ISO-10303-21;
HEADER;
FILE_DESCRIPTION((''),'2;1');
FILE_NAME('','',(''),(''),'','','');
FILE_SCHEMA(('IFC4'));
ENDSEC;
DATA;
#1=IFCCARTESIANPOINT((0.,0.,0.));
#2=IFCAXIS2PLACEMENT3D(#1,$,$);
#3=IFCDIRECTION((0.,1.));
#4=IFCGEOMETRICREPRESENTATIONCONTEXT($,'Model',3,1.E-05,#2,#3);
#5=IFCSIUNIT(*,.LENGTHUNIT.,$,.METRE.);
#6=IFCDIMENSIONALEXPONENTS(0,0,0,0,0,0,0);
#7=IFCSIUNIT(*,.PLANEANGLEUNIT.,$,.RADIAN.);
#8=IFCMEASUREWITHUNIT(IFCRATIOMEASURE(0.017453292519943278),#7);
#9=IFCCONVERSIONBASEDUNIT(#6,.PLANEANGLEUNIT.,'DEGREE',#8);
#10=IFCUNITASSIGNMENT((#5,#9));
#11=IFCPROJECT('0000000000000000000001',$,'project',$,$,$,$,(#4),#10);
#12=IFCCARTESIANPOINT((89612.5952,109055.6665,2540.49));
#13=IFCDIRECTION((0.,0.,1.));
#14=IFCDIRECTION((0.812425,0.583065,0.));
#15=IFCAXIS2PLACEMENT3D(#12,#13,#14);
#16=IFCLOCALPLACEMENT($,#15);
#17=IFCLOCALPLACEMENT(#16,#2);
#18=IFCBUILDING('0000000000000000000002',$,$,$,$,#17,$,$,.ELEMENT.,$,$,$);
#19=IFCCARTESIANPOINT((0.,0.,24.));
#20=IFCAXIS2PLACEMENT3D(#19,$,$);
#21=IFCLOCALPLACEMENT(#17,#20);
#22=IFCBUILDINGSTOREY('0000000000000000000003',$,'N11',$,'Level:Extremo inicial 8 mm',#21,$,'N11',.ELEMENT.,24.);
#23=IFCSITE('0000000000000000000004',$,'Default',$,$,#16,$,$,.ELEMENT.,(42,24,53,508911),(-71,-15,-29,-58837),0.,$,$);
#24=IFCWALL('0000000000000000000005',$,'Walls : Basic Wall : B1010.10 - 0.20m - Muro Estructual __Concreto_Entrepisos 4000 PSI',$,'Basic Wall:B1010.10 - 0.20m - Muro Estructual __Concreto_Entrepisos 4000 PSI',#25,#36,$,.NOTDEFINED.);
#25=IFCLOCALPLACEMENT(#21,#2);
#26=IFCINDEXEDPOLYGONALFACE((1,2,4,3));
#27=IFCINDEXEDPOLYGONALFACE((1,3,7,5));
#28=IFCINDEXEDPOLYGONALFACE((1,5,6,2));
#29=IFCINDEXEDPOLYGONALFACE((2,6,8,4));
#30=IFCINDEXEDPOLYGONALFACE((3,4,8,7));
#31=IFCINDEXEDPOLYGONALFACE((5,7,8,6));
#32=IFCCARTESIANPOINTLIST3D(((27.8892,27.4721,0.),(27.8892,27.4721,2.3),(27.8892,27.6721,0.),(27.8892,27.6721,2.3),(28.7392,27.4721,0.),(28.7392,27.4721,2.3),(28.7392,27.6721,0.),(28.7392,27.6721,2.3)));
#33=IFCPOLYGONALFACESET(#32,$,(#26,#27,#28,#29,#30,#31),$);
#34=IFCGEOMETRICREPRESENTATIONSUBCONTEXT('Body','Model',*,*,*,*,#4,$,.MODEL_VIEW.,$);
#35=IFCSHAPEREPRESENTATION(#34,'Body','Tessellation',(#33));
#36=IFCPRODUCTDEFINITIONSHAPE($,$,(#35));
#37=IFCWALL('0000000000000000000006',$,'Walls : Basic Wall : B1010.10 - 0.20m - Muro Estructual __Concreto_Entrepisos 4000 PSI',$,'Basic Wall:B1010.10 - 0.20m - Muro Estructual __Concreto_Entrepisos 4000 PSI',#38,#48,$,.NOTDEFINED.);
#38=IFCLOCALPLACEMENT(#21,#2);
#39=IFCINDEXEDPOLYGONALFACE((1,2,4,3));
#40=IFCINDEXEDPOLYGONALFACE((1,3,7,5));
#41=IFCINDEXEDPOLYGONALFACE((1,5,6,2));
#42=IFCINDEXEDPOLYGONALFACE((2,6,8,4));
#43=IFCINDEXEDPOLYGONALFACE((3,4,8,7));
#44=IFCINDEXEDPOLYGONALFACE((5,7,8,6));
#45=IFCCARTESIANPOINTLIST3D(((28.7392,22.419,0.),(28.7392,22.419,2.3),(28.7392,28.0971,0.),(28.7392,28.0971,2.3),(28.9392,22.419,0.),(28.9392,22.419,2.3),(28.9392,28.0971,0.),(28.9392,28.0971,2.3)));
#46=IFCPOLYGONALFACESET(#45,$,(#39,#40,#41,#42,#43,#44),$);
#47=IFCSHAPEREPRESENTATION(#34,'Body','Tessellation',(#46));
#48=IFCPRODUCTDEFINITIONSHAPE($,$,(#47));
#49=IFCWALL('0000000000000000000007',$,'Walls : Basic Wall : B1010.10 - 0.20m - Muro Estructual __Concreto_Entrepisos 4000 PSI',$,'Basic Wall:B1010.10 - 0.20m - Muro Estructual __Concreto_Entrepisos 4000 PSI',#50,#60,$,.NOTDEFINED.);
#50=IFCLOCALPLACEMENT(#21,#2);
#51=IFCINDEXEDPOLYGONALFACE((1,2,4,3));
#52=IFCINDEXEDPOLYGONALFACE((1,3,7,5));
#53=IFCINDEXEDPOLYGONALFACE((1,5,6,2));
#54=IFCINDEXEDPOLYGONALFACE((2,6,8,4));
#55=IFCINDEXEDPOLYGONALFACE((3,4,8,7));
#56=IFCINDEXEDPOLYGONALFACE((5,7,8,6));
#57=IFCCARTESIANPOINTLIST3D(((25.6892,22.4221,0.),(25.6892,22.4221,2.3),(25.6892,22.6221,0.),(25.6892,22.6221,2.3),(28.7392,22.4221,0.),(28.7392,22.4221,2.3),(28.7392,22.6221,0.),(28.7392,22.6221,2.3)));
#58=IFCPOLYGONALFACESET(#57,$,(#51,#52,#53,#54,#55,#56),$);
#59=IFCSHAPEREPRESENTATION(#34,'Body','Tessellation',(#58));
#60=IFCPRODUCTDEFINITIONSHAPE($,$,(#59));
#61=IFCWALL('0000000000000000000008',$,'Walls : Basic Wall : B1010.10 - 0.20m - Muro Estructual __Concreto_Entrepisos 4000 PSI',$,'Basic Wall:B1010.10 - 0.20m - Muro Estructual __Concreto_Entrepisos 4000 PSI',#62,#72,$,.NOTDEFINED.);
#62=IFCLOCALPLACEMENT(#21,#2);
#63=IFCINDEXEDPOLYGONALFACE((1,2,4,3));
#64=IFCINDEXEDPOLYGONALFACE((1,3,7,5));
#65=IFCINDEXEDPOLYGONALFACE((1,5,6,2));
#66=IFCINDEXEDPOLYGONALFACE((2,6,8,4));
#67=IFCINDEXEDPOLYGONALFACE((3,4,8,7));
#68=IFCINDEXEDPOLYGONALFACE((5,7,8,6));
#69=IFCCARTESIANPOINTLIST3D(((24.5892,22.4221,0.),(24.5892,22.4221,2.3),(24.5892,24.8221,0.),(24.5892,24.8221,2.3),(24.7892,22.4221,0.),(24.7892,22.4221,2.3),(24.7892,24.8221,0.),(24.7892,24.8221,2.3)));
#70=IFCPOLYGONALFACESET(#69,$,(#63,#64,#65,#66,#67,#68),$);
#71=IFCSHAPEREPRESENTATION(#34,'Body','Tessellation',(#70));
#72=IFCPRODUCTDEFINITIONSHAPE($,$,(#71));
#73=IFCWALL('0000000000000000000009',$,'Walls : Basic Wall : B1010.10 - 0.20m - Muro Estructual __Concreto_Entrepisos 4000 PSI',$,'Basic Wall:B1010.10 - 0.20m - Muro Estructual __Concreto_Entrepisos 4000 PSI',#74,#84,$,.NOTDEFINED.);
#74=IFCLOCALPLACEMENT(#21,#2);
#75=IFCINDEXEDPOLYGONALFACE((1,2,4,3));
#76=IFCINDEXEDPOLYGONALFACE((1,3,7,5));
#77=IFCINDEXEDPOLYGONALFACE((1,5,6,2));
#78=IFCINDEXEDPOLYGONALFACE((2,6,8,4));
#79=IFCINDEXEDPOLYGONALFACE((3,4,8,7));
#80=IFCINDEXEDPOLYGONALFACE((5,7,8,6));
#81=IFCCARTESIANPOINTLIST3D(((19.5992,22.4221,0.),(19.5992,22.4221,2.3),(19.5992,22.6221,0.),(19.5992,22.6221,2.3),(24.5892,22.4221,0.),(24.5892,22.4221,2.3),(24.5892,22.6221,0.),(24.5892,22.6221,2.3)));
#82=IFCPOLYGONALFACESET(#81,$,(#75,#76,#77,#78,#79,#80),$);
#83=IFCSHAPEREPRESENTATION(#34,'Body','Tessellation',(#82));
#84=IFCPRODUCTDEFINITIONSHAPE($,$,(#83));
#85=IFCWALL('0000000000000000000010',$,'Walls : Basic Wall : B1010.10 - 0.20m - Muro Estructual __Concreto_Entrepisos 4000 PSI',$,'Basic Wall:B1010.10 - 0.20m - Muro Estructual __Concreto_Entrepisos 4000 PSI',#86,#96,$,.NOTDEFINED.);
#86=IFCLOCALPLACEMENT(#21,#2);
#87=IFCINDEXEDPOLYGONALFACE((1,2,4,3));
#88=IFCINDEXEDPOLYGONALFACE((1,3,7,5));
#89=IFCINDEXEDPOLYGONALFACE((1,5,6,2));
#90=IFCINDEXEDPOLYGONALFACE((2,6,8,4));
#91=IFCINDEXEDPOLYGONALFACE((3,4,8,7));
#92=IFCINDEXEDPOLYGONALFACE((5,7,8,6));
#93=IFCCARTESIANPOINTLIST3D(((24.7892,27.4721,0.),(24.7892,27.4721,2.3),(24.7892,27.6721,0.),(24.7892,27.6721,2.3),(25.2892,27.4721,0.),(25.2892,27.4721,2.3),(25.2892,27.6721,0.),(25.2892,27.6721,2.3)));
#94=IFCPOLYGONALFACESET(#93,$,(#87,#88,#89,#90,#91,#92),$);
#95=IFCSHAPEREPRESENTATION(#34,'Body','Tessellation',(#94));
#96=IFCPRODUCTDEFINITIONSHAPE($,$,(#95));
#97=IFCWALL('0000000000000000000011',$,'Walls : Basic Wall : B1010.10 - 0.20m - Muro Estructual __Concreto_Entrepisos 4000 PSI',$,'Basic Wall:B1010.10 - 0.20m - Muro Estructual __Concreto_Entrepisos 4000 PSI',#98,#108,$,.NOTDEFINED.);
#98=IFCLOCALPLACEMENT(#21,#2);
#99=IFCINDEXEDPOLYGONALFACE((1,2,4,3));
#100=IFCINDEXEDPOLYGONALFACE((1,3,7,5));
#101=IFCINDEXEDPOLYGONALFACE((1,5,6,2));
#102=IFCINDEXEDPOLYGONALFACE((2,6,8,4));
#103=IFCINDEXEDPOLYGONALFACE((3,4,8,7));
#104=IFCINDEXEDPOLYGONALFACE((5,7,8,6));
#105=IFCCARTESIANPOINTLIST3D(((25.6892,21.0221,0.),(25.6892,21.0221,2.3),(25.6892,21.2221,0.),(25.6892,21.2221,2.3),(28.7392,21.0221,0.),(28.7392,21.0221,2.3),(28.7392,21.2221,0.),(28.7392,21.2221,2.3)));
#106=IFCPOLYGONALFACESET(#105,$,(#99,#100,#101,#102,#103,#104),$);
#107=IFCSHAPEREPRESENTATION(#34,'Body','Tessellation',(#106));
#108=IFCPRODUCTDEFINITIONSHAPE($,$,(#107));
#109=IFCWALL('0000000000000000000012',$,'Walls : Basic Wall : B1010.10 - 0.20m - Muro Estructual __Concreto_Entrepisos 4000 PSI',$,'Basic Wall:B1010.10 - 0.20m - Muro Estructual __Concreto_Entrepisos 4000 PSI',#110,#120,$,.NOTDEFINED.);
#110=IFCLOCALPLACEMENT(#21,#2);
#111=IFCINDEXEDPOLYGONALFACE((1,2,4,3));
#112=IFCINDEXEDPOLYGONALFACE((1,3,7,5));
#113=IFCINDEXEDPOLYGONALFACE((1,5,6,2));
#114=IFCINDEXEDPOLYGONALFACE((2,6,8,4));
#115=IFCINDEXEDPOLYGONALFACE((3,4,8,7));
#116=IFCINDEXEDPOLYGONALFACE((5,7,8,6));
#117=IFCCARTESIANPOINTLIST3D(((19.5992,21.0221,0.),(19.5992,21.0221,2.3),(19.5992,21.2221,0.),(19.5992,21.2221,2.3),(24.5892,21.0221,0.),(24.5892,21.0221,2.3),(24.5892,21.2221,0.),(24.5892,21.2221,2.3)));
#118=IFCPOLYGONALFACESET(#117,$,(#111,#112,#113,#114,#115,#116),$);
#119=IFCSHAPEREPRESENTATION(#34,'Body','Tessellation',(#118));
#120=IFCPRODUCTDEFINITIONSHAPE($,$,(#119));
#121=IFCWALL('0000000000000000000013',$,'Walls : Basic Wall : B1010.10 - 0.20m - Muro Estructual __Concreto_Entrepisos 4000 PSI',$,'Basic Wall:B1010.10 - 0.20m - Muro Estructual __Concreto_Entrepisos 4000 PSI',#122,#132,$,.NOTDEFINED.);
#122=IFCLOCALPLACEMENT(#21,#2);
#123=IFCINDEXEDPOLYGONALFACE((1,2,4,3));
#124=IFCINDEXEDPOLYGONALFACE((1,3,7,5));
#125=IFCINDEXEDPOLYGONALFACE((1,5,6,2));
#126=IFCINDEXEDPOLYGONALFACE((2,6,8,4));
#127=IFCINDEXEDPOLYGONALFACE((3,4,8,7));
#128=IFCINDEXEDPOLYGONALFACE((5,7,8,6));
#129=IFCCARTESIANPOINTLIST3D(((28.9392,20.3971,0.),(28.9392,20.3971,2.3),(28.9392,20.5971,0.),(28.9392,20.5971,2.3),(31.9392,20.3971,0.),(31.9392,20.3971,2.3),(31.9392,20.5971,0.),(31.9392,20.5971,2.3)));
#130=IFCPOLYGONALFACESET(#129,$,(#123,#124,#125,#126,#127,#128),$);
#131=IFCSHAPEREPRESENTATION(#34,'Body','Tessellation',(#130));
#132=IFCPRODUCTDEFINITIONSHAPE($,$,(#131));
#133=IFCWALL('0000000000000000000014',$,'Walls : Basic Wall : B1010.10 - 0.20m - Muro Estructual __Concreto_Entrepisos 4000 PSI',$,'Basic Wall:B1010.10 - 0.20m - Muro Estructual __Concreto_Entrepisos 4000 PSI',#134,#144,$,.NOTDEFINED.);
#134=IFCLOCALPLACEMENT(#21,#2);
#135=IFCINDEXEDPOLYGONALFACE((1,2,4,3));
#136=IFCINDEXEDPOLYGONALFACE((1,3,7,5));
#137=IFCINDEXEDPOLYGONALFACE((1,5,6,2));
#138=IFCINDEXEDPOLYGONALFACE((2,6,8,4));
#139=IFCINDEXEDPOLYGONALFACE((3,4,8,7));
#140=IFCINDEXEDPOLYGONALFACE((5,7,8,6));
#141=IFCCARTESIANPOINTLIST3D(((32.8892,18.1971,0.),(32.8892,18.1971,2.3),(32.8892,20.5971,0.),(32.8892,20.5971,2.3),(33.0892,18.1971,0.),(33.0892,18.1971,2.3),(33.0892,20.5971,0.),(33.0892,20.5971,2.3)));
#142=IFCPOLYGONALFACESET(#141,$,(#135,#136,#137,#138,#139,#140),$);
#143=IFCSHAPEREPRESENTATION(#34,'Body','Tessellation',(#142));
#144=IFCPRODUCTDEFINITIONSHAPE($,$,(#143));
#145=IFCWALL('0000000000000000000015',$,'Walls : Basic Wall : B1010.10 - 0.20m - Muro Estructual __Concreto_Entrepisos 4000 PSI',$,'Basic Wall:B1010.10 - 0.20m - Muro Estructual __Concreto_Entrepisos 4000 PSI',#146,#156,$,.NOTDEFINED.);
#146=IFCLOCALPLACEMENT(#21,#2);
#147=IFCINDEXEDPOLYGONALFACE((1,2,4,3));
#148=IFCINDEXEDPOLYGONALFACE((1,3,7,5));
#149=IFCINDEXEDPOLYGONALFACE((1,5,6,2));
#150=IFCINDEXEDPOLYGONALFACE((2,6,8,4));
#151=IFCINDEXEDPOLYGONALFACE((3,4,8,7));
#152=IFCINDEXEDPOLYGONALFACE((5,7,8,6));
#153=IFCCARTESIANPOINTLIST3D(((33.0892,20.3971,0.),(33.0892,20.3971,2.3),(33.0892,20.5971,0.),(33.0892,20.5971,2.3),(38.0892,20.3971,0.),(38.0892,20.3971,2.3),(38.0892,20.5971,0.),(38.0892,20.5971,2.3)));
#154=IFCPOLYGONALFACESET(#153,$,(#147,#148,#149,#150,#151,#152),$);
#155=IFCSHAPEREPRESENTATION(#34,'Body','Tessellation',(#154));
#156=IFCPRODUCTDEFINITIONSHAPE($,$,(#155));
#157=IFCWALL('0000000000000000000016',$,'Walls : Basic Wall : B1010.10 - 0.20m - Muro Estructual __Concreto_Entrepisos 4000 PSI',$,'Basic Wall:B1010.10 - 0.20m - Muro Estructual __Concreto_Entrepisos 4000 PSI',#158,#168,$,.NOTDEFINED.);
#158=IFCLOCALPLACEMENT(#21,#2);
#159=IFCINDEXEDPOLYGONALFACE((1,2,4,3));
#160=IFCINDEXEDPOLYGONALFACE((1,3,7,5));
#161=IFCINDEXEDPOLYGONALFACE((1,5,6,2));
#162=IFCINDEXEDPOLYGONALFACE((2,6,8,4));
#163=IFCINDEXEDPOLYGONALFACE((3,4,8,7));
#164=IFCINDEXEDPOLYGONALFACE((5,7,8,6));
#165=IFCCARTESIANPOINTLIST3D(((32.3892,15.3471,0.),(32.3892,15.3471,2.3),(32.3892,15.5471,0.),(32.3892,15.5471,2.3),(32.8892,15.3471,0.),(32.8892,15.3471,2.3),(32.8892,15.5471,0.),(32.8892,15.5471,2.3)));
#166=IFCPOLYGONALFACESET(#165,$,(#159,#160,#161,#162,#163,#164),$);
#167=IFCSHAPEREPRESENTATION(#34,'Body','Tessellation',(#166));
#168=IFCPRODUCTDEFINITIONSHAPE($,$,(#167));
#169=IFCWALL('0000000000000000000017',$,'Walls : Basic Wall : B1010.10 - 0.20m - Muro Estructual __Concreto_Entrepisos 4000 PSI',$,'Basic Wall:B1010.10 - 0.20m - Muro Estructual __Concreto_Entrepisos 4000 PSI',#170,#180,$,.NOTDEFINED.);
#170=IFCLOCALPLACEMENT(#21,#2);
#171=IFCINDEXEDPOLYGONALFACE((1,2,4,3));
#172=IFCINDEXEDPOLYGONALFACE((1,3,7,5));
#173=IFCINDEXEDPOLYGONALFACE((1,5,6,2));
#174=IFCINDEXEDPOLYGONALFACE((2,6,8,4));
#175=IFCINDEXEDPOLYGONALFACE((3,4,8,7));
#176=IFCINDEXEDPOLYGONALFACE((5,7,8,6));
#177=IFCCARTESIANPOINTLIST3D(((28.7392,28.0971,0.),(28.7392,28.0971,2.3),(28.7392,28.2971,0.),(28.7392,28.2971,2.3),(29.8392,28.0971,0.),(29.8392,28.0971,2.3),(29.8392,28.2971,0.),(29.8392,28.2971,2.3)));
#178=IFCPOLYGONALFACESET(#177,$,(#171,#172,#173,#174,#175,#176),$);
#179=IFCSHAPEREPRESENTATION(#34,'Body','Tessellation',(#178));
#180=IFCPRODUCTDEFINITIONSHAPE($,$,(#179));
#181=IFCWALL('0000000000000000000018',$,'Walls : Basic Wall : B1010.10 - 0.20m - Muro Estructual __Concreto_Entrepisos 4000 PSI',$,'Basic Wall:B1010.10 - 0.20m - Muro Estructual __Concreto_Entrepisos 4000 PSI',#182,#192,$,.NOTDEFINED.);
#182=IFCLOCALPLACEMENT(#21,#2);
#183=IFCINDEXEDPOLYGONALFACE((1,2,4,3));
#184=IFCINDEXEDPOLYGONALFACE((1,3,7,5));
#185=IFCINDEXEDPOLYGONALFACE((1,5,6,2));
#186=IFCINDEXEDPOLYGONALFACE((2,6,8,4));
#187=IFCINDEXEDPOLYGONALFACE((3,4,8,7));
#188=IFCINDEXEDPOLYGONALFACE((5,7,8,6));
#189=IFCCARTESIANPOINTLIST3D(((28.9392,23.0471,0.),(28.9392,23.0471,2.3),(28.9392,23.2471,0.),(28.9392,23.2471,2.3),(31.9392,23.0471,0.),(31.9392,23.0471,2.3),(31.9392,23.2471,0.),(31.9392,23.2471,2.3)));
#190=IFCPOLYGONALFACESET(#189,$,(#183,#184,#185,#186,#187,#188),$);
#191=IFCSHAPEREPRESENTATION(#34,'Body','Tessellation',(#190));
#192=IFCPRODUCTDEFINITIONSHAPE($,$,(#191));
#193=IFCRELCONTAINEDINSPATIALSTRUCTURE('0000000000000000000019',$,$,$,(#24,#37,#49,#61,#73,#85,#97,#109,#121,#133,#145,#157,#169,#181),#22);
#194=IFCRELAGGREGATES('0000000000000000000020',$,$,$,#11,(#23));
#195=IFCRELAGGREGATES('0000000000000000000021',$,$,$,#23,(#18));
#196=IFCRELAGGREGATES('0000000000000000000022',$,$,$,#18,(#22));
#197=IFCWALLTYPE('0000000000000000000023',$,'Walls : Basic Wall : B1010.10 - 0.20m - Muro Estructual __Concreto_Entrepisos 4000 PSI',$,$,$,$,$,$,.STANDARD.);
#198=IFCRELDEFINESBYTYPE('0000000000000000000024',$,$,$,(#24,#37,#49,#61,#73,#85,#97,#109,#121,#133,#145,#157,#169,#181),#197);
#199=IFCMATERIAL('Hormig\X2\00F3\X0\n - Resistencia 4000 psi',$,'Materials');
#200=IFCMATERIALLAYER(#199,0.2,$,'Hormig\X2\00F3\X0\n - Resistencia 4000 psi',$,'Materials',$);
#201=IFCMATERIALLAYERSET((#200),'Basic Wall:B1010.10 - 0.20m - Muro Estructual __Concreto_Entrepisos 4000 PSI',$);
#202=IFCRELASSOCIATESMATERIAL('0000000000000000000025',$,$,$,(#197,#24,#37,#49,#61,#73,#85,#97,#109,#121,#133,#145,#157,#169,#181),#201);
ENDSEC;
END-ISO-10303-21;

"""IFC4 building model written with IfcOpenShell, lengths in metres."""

from ifc_helpers import new_model, entity, si_unit, converted_unit, direction, frame, frame_2d, origin, place, context, subcontext, project, spatial, rectangle, extrude, material, layer, layer_set, layer_usage, type_object, element, save


model = new_model("IFC4")

# Units and contexts
model_context = context("Model", 3, precision=1e-05, world=origin(), true_north=direction((0.0, 1.0)))
body_context = subcontext(model_context, "Body", "Model", "MODEL_VIEW")
ifc_project = project(units=[si_unit("LENGTHUNIT", "METRE"), converted_unit("PLANEANGLEUNIT", "DEGREE", entity("IfcRatioMeasure", 0.017453292519943278), si_unit("PLANEANGLEUNIT", "RADIAN"), dimensions=[0, 0, 0, 0, 0, 0, 0])], contexts=[model_context])

# Site, building, storey
site_placement = place(None, frame((89612.5952, 109055.6665, 2540.49), z_axis=(0.0, 0.0, 1.0), x_axis=(0.812425, 0.583065, 0.0)))
site = spatial("IfcSite", under=ifc_project, at=site_placement, Name="Default", CompositionType="ELEMENT", RefLatitude=(42, 24, 53, 508911), RefLongitude=(-71, -15, -29, -58837), RefElevation=0.0)
building_placement = place(site_placement, origin())
building = spatial("IfcBuilding", under=site, at=building_placement, CompositionType="ELEMENT")
storey_placement = place(building_placement, frame((0.0, 0.0, 24.0)))
storey = spatial("IfcBuildingStorey", under=building, at=storey_placement, Name="N11", ObjectType="Level:Extremo inicial 8 mm", LongName="N11", CompositionType="ELEMENT", Elevation=24.0)

# Walls
ifc_material = material(Name="Hormigón - Resistencia 4000 psi", Category="Materials")
ifc_layer_1 = layer(ifc_material, 0.2, Name="Hormigón - Resistencia 4000 psi", Category="Materials")
ifc_layer_set_1 = layer_set([ifc_layer_1], Name="Basic Wall:B1010.10 - 0.20m - Muro Estructual __Concreto_Entrepisos 4000 PSI")
ifc_layer_usage_1 = layer_usage(ifc_layer_set_1, "AXIS2", "NEGATIVE", 0.1)
wall_type_1 = type_object("IfcWallType", Name="Walls : Basic Wall : B1010.10 - 0.20m - Muro Estructual __Concreto_Entrepisos 4000 PSI", PredefinedType="STANDARD", material=ifc_layer_set_1)
wall_1_placement = place(storey_placement, frame((27.8892, 27.5721, 0.0)))
element("IfcWall", 1, at=wall_1_placement, inside=storey, type_object=wall_type_1, material=ifc_layer_usage_1, Name="Walls : Basic Wall : B1010.10 - 0.20m - Muro Estructual __Concreto_Entrepisos 4000 PSI", ObjectType="Basic Wall:B1010.10 - 0.20m - Muro Estructual __Concreto_Entrepisos 4000 PSI", PredefinedType="NOTDEFINED", context=body_context, shape_type="SweptSolid", body=[
    extrude(rectangle(XDim=0.85, YDim=0.2, at=frame_2d((0.425, 0.0), x_axis=(-1.0, 0.0))), origin(), (0.0, 0.0, 1.0), 2.3),
])
ifc_layer_usage_2 = layer_usage(ifc_layer_set_1, "AXIS2", "NEGATIVE", 0.1)
wall_2_placement = place(storey_placement, frame((28.8392, 28.0971, 0.0), z_axis=(0.0, 0.0, 1.0), x_axis=(0.0, -1.0, 0.0)))
element("IfcWall", 2, at=wall_2_placement, inside=storey, type_object=wall_type_1, material=ifc_layer_usage_2, Name="Walls : Basic Wall : B1010.10 - 0.20m - Muro Estructual __Concreto_Entrepisos 4000 PSI", ObjectType="Basic Wall:B1010.10 - 0.20m - Muro Estructual __Concreto_Entrepisos 4000 PSI", PredefinedType="NOTDEFINED", context=body_context, shape_type="SweptSolid", body=[
    extrude(rectangle(XDim=5.6781, YDim=0.2, at=frame_2d((2.839, 0.0), x_axis=(-1.0, 0.0))), origin(), (0.0, 0.0, 1.0), 2.3),
])
ifc_layer_usage_3 = layer_usage(ifc_layer_set_1, "AXIS2", "NEGATIVE", 0.1)
wall_3_placement = place(storey_placement, frame((28.7392, 22.5221, 0.0), z_axis=(0.0, 0.0, 1.0), x_axis=(-1.0, 0.0, 0.0)))
element("IfcWall", 3, at=wall_3_placement, inside=storey, type_object=wall_type_1, material=ifc_layer_usage_3, Name="Walls : Basic Wall : B1010.10 - 0.20m - Muro Estructual __Concreto_Entrepisos 4000 PSI", ObjectType="Basic Wall:B1010.10 - 0.20m - Muro Estructual __Concreto_Entrepisos 4000 PSI", PredefinedType="NOTDEFINED", context=body_context, shape_type="SweptSolid", body=[
    extrude(rectangle(XDim=3.05, YDim=0.2, at=frame_2d((1.525, 0.0), x_axis=(-1.0, 0.0))), origin(), (0.0, 0.0, 1.0), 2.3),
])
ifc_layer_usage_4 = layer_usage(ifc_layer_set_1, "AXIS2", "NEGATIVE", 0.1)
wall_4_placement = place(storey_placement, frame((24.6892, 24.8221, 0.0), z_axis=(0.0, 0.0, 1.0), x_axis=(0.0, -1.0, 0.0)))
element("IfcWall", 4, at=wall_4_placement, inside=storey, type_object=wall_type_1, material=ifc_layer_usage_4, Name="Walls : Basic Wall : B1010.10 - 0.20m - Muro Estructual __Concreto_Entrepisos 4000 PSI", ObjectType="Basic Wall:B1010.10 - 0.20m - Muro Estructual __Concreto_Entrepisos 4000 PSI", PredefinedType="NOTDEFINED", context=body_context, shape_type="SweptSolid", body=[
    extrude(rectangle(XDim=2.4, YDim=0.2, at=frame_2d((1.2, 0.0), x_axis=(-1.0, 0.0))), origin(), (0.0, 0.0, 1.0), 2.3),
])
ifc_layer_usage_5 = layer_usage(ifc_layer_set_1, "AXIS2", "NEGATIVE", 0.1)
wall_5_placement = place(storey_placement, frame((24.5892, 22.5221, 0.0), z_axis=(0.0, 0.0, 1.0), x_axis=(-1.0, 0.0, 0.0)))
element("IfcWall", 5, at=wall_5_placement, inside=storey, type_object=wall_type_1, material=ifc_layer_usage_5, Name="Walls : Basic Wall : B1010.10 - 0.20m - Muro Estructual __Concreto_Entrepisos 4000 PSI", ObjectType="Basic Wall:B1010.10 - 0.20m - Muro Estructual __Concreto_Entrepisos 4000 PSI", PredefinedType="NOTDEFINED", context=body_context, shape_type="SweptSolid", body=[
    extrude(rectangle(XDim=4.99, YDim=0.2, at=frame_2d((2.495, 0.0), x_axis=(-1.0, 0.0))), origin(), (0.0, 0.0, 1.0), 2.3),
])
ifc_layer_usage_6 = layer_usage(ifc_layer_set_1, "AXIS2", "NEGATIVE", 0.1)
wall_6_placement = place(storey_placement, frame((25.2892, 27.5721, 0.0), z_axis=(0.0, 0.0, 1.0), x_axis=(-1.0, 0.0, 0.0)))
element("IfcWall", 6, at=wall_6_placement, inside=storey, type_object=wall_type_1, material=ifc_layer_usage_6, Name="Walls : Basic Wall : B1010.10 - 0.20m - Muro Estructual __Concreto_Entrepisos 4000 PSI", ObjectType="Basic Wall:B1010.10 - 0.20m - Muro Estructual __Concreto_Entrepisos 4000 PSI", PredefinedType="NOTDEFINED", context=body_context, shape_type="SweptSolid", body=[
    extrude(rectangle(XDim=0.5, YDim=0.2, at=frame_2d((0.25, 0.0), x_axis=(-1.0, 0.0))), origin(), (0.0, 0.0, 1.0), 2.3),
])
ifc_layer_usage_7 = layer_usage(ifc_layer_set_1, "AXIS2", "POSITIVE", -0.1)
wall_7_placement = place(storey_placement, frame((28.7392, 21.1221, 0.0), z_axis=(0.0, 0.0, 1.0), x_axis=(-1.0, 0.0, 0.0)))
element("IfcWall", 7, at=wall_7_placement, inside=storey, type_object=wall_type_1, material=ifc_layer_usage_7, Name="Walls : Basic Wall : B1010.10 - 0.20m - Muro Estructual __Concreto_Entrepisos 4000 PSI", ObjectType="Basic Wall:B1010.10 - 0.20m - Muro Estructual __Concreto_Entrepisos 4000 PSI", PredefinedType="NOTDEFINED", context=body_context, shape_type="SweptSolid", body=[
    extrude(rectangle(XDim=3.05, YDim=0.2, at=frame_2d((1.525, 0.0), x_axis=(-1.0, 0.0))), origin(), (0.0, 0.0, 1.0), 2.3),
])
ifc_layer_usage_8 = layer_usage(ifc_layer_set_1, "AXIS2", "POSITIVE", -0.1)
wall_8_placement = place(storey_placement, frame((24.5892, 21.1221, 0.0), z_axis=(0.0, 0.0, 1.0), x_axis=(-1.0, 0.0, 0.0)))
element("IfcWall", 8, at=wall_8_placement, inside=storey, type_object=wall_type_1, material=ifc_layer_usage_8, Name="Walls : Basic Wall : B1010.10 - 0.20m - Muro Estructual __Concreto_Entrepisos 4000 PSI", ObjectType="Basic Wall:B1010.10 - 0.20m - Muro Estructual __Concreto_Entrepisos 4000 PSI", PredefinedType="NOTDEFINED", context=body_context, shape_type="SweptSolid", body=[
    extrude(rectangle(XDim=4.99, YDim=0.2, at=frame_2d((2.495, 0.0), x_axis=(-1.0, 0.0))), origin(), (0.0, 0.0, 1.0), 2.3),
])
ifc_layer_usage_9 = layer_usage(ifc_layer_set_1, "AXIS2", "NEGATIVE", 0.1)
wall_9_placement = place(storey_placement, frame((28.9392, 20.4971, 0.0)))
element("IfcWall", 9, at=wall_9_placement, inside=storey, type_object=wall_type_1, material=ifc_layer_usage_9, Name="Walls : Basic Wall : B1010.10 - 0.20m - Muro Estructual __Concreto_Entrepisos 4000 PSI", ObjectType="Basic Wall:B1010.10 - 0.20m - Muro Estructual __Concreto_Entrepisos 4000 PSI", PredefinedType="NOTDEFINED", context=body_context, shape_type="SweptSolid", body=[
    extrude(rectangle(XDim=3.0, YDim=0.2, at=frame_2d((1.5, 0.0), x_axis=(-1.0, 0.0))), origin(), (0.0, 0.0, 1.0), 2.3),
])
ifc_layer_usage_10 = layer_usage(ifc_layer_set_1, "AXIS2", "NEGATIVE", 0.1)
wall_10_placement = place(storey_placement, frame((32.9892, 18.1971, 0.0), z_axis=(0.0, 0.0, 1.0), x_axis=(0.0, 1.0, 0.0)))
element("IfcWall", 10, at=wall_10_placement, inside=storey, type_object=wall_type_1, material=ifc_layer_usage_10, Name="Walls : Basic Wall : B1010.10 - 0.20m - Muro Estructual __Concreto_Entrepisos 4000 PSI", ObjectType="Basic Wall:B1010.10 - 0.20m - Muro Estructual __Concreto_Entrepisos 4000 PSI", PredefinedType="NOTDEFINED", context=body_context, shape_type="SweptSolid", body=[
    extrude(rectangle(XDim=2.4, YDim=0.2, at=frame_2d((1.2, 0.0), x_axis=(-1.0, 0.0))), origin(), (0.0, 0.0, 1.0), 2.3),
])
ifc_layer_usage_11 = layer_usage(ifc_layer_set_1, "AXIS2", "NEGATIVE", 0.1)
wall_11_placement = place(storey_placement, frame((33.0892, 20.4971, 0.0)))
element("IfcWall", 11, at=wall_11_placement, inside=storey, type_object=wall_type_1, material=ifc_layer_usage_11, Name="Walls : Basic Wall : B1010.10 - 0.20m - Muro Estructual __Concreto_Entrepisos 4000 PSI", ObjectType="Basic Wall:B1010.10 - 0.20m - Muro Estructual __Concreto_Entrepisos 4000 PSI", PredefinedType="NOTDEFINED", context=body_context, shape_type="SweptSolid", body=[
    extrude(rectangle(XDim=5.0, YDim=0.2, at=frame_2d((2.5, 0.0), x_axis=(-1.0, 0.0))), origin(), (0.0, 0.0, 1.0), 2.3),
])
ifc_layer_usage_12 = layer_usage(ifc_layer_set_1, "AXIS2", "NEGATIVE", 0.1)
wall_12_placement = place(storey_placement, frame((32.3892, 15.4471, 0.0)))
element("IfcWall", 12, at=wall_12_placement, inside=storey, type_object=wall_type_1, material=ifc_layer_usage_12, Name="Walls : Basic Wall : B1010.10 - 0.20m - Muro Estructual __Concreto_Entrepisos 4000 PSI", ObjectType="Basic Wall:B1010.10 - 0.20m - Muro Estructual __Concreto_Entrepisos 4000 PSI", PredefinedType="NOTDEFINED", context=body_context, shape_type="SweptSolid", body=[
    extrude(rectangle(XDim=0.5, YDim=0.2, at=frame_2d((0.25, 0.0), x_axis=(-1.0, 0.0))), origin(), (0.0, 0.0, 1.0), 2.3),
])
ifc_layer_usage_13 = layer_usage(ifc_layer_set_1, "AXIS2", "POSITIVE", -0.1)
wall_13_placement = place(storey_placement, frame((29.8392, 28.1971, 0.0), z_axis=(0.0, 0.0, 1.0), x_axis=(-1.0, 0.0, 0.0)))
element("IfcWall", 13, at=wall_13_placement, inside=storey, type_object=wall_type_1, material=ifc_layer_usage_13, Name="Walls : Basic Wall : B1010.10 - 0.20m - Muro Estructual __Concreto_Entrepisos 4000 PSI", ObjectType="Basic Wall:B1010.10 - 0.20m - Muro Estructual __Concreto_Entrepisos 4000 PSI", PredefinedType="NOTDEFINED", context=body_context, shape_type="SweptSolid", body=[
    extrude(rectangle(XDim=1.1, YDim=0.2, at=frame_2d((0.55, 0.0), x_axis=(-1.0, 0.0))), origin(), (0.0, 0.0, 1.0), 2.3),
])
ifc_layer_usage_14 = layer_usage(ifc_layer_set_1, "AXIS2", "POSITIVE", -0.1)
wall_14_placement = place(storey_placement, frame((28.9392, 23.1471, 0.0)))
element("IfcWall", 14, at=wall_14_placement, inside=storey, type_object=wall_type_1, material=ifc_layer_usage_14, Name="Walls : Basic Wall : B1010.10 - 0.20m - Muro Estructual __Concreto_Entrepisos 4000 PSI", ObjectType="Basic Wall:B1010.10 - 0.20m - Muro Estructual __Concreto_Entrepisos 4000 PSI", PredefinedType="NOTDEFINED", context=body_context, shape_type="SweptSolid", body=[
    extrude(rectangle(XDim=3.0, YDim=0.2, at=frame_2d((1.5, 0.0), x_axis=(-1.0, 0.0))), origin(), (0.0, 0.0, 1.0), 2.3),
])

save(model, "model.ifc")
